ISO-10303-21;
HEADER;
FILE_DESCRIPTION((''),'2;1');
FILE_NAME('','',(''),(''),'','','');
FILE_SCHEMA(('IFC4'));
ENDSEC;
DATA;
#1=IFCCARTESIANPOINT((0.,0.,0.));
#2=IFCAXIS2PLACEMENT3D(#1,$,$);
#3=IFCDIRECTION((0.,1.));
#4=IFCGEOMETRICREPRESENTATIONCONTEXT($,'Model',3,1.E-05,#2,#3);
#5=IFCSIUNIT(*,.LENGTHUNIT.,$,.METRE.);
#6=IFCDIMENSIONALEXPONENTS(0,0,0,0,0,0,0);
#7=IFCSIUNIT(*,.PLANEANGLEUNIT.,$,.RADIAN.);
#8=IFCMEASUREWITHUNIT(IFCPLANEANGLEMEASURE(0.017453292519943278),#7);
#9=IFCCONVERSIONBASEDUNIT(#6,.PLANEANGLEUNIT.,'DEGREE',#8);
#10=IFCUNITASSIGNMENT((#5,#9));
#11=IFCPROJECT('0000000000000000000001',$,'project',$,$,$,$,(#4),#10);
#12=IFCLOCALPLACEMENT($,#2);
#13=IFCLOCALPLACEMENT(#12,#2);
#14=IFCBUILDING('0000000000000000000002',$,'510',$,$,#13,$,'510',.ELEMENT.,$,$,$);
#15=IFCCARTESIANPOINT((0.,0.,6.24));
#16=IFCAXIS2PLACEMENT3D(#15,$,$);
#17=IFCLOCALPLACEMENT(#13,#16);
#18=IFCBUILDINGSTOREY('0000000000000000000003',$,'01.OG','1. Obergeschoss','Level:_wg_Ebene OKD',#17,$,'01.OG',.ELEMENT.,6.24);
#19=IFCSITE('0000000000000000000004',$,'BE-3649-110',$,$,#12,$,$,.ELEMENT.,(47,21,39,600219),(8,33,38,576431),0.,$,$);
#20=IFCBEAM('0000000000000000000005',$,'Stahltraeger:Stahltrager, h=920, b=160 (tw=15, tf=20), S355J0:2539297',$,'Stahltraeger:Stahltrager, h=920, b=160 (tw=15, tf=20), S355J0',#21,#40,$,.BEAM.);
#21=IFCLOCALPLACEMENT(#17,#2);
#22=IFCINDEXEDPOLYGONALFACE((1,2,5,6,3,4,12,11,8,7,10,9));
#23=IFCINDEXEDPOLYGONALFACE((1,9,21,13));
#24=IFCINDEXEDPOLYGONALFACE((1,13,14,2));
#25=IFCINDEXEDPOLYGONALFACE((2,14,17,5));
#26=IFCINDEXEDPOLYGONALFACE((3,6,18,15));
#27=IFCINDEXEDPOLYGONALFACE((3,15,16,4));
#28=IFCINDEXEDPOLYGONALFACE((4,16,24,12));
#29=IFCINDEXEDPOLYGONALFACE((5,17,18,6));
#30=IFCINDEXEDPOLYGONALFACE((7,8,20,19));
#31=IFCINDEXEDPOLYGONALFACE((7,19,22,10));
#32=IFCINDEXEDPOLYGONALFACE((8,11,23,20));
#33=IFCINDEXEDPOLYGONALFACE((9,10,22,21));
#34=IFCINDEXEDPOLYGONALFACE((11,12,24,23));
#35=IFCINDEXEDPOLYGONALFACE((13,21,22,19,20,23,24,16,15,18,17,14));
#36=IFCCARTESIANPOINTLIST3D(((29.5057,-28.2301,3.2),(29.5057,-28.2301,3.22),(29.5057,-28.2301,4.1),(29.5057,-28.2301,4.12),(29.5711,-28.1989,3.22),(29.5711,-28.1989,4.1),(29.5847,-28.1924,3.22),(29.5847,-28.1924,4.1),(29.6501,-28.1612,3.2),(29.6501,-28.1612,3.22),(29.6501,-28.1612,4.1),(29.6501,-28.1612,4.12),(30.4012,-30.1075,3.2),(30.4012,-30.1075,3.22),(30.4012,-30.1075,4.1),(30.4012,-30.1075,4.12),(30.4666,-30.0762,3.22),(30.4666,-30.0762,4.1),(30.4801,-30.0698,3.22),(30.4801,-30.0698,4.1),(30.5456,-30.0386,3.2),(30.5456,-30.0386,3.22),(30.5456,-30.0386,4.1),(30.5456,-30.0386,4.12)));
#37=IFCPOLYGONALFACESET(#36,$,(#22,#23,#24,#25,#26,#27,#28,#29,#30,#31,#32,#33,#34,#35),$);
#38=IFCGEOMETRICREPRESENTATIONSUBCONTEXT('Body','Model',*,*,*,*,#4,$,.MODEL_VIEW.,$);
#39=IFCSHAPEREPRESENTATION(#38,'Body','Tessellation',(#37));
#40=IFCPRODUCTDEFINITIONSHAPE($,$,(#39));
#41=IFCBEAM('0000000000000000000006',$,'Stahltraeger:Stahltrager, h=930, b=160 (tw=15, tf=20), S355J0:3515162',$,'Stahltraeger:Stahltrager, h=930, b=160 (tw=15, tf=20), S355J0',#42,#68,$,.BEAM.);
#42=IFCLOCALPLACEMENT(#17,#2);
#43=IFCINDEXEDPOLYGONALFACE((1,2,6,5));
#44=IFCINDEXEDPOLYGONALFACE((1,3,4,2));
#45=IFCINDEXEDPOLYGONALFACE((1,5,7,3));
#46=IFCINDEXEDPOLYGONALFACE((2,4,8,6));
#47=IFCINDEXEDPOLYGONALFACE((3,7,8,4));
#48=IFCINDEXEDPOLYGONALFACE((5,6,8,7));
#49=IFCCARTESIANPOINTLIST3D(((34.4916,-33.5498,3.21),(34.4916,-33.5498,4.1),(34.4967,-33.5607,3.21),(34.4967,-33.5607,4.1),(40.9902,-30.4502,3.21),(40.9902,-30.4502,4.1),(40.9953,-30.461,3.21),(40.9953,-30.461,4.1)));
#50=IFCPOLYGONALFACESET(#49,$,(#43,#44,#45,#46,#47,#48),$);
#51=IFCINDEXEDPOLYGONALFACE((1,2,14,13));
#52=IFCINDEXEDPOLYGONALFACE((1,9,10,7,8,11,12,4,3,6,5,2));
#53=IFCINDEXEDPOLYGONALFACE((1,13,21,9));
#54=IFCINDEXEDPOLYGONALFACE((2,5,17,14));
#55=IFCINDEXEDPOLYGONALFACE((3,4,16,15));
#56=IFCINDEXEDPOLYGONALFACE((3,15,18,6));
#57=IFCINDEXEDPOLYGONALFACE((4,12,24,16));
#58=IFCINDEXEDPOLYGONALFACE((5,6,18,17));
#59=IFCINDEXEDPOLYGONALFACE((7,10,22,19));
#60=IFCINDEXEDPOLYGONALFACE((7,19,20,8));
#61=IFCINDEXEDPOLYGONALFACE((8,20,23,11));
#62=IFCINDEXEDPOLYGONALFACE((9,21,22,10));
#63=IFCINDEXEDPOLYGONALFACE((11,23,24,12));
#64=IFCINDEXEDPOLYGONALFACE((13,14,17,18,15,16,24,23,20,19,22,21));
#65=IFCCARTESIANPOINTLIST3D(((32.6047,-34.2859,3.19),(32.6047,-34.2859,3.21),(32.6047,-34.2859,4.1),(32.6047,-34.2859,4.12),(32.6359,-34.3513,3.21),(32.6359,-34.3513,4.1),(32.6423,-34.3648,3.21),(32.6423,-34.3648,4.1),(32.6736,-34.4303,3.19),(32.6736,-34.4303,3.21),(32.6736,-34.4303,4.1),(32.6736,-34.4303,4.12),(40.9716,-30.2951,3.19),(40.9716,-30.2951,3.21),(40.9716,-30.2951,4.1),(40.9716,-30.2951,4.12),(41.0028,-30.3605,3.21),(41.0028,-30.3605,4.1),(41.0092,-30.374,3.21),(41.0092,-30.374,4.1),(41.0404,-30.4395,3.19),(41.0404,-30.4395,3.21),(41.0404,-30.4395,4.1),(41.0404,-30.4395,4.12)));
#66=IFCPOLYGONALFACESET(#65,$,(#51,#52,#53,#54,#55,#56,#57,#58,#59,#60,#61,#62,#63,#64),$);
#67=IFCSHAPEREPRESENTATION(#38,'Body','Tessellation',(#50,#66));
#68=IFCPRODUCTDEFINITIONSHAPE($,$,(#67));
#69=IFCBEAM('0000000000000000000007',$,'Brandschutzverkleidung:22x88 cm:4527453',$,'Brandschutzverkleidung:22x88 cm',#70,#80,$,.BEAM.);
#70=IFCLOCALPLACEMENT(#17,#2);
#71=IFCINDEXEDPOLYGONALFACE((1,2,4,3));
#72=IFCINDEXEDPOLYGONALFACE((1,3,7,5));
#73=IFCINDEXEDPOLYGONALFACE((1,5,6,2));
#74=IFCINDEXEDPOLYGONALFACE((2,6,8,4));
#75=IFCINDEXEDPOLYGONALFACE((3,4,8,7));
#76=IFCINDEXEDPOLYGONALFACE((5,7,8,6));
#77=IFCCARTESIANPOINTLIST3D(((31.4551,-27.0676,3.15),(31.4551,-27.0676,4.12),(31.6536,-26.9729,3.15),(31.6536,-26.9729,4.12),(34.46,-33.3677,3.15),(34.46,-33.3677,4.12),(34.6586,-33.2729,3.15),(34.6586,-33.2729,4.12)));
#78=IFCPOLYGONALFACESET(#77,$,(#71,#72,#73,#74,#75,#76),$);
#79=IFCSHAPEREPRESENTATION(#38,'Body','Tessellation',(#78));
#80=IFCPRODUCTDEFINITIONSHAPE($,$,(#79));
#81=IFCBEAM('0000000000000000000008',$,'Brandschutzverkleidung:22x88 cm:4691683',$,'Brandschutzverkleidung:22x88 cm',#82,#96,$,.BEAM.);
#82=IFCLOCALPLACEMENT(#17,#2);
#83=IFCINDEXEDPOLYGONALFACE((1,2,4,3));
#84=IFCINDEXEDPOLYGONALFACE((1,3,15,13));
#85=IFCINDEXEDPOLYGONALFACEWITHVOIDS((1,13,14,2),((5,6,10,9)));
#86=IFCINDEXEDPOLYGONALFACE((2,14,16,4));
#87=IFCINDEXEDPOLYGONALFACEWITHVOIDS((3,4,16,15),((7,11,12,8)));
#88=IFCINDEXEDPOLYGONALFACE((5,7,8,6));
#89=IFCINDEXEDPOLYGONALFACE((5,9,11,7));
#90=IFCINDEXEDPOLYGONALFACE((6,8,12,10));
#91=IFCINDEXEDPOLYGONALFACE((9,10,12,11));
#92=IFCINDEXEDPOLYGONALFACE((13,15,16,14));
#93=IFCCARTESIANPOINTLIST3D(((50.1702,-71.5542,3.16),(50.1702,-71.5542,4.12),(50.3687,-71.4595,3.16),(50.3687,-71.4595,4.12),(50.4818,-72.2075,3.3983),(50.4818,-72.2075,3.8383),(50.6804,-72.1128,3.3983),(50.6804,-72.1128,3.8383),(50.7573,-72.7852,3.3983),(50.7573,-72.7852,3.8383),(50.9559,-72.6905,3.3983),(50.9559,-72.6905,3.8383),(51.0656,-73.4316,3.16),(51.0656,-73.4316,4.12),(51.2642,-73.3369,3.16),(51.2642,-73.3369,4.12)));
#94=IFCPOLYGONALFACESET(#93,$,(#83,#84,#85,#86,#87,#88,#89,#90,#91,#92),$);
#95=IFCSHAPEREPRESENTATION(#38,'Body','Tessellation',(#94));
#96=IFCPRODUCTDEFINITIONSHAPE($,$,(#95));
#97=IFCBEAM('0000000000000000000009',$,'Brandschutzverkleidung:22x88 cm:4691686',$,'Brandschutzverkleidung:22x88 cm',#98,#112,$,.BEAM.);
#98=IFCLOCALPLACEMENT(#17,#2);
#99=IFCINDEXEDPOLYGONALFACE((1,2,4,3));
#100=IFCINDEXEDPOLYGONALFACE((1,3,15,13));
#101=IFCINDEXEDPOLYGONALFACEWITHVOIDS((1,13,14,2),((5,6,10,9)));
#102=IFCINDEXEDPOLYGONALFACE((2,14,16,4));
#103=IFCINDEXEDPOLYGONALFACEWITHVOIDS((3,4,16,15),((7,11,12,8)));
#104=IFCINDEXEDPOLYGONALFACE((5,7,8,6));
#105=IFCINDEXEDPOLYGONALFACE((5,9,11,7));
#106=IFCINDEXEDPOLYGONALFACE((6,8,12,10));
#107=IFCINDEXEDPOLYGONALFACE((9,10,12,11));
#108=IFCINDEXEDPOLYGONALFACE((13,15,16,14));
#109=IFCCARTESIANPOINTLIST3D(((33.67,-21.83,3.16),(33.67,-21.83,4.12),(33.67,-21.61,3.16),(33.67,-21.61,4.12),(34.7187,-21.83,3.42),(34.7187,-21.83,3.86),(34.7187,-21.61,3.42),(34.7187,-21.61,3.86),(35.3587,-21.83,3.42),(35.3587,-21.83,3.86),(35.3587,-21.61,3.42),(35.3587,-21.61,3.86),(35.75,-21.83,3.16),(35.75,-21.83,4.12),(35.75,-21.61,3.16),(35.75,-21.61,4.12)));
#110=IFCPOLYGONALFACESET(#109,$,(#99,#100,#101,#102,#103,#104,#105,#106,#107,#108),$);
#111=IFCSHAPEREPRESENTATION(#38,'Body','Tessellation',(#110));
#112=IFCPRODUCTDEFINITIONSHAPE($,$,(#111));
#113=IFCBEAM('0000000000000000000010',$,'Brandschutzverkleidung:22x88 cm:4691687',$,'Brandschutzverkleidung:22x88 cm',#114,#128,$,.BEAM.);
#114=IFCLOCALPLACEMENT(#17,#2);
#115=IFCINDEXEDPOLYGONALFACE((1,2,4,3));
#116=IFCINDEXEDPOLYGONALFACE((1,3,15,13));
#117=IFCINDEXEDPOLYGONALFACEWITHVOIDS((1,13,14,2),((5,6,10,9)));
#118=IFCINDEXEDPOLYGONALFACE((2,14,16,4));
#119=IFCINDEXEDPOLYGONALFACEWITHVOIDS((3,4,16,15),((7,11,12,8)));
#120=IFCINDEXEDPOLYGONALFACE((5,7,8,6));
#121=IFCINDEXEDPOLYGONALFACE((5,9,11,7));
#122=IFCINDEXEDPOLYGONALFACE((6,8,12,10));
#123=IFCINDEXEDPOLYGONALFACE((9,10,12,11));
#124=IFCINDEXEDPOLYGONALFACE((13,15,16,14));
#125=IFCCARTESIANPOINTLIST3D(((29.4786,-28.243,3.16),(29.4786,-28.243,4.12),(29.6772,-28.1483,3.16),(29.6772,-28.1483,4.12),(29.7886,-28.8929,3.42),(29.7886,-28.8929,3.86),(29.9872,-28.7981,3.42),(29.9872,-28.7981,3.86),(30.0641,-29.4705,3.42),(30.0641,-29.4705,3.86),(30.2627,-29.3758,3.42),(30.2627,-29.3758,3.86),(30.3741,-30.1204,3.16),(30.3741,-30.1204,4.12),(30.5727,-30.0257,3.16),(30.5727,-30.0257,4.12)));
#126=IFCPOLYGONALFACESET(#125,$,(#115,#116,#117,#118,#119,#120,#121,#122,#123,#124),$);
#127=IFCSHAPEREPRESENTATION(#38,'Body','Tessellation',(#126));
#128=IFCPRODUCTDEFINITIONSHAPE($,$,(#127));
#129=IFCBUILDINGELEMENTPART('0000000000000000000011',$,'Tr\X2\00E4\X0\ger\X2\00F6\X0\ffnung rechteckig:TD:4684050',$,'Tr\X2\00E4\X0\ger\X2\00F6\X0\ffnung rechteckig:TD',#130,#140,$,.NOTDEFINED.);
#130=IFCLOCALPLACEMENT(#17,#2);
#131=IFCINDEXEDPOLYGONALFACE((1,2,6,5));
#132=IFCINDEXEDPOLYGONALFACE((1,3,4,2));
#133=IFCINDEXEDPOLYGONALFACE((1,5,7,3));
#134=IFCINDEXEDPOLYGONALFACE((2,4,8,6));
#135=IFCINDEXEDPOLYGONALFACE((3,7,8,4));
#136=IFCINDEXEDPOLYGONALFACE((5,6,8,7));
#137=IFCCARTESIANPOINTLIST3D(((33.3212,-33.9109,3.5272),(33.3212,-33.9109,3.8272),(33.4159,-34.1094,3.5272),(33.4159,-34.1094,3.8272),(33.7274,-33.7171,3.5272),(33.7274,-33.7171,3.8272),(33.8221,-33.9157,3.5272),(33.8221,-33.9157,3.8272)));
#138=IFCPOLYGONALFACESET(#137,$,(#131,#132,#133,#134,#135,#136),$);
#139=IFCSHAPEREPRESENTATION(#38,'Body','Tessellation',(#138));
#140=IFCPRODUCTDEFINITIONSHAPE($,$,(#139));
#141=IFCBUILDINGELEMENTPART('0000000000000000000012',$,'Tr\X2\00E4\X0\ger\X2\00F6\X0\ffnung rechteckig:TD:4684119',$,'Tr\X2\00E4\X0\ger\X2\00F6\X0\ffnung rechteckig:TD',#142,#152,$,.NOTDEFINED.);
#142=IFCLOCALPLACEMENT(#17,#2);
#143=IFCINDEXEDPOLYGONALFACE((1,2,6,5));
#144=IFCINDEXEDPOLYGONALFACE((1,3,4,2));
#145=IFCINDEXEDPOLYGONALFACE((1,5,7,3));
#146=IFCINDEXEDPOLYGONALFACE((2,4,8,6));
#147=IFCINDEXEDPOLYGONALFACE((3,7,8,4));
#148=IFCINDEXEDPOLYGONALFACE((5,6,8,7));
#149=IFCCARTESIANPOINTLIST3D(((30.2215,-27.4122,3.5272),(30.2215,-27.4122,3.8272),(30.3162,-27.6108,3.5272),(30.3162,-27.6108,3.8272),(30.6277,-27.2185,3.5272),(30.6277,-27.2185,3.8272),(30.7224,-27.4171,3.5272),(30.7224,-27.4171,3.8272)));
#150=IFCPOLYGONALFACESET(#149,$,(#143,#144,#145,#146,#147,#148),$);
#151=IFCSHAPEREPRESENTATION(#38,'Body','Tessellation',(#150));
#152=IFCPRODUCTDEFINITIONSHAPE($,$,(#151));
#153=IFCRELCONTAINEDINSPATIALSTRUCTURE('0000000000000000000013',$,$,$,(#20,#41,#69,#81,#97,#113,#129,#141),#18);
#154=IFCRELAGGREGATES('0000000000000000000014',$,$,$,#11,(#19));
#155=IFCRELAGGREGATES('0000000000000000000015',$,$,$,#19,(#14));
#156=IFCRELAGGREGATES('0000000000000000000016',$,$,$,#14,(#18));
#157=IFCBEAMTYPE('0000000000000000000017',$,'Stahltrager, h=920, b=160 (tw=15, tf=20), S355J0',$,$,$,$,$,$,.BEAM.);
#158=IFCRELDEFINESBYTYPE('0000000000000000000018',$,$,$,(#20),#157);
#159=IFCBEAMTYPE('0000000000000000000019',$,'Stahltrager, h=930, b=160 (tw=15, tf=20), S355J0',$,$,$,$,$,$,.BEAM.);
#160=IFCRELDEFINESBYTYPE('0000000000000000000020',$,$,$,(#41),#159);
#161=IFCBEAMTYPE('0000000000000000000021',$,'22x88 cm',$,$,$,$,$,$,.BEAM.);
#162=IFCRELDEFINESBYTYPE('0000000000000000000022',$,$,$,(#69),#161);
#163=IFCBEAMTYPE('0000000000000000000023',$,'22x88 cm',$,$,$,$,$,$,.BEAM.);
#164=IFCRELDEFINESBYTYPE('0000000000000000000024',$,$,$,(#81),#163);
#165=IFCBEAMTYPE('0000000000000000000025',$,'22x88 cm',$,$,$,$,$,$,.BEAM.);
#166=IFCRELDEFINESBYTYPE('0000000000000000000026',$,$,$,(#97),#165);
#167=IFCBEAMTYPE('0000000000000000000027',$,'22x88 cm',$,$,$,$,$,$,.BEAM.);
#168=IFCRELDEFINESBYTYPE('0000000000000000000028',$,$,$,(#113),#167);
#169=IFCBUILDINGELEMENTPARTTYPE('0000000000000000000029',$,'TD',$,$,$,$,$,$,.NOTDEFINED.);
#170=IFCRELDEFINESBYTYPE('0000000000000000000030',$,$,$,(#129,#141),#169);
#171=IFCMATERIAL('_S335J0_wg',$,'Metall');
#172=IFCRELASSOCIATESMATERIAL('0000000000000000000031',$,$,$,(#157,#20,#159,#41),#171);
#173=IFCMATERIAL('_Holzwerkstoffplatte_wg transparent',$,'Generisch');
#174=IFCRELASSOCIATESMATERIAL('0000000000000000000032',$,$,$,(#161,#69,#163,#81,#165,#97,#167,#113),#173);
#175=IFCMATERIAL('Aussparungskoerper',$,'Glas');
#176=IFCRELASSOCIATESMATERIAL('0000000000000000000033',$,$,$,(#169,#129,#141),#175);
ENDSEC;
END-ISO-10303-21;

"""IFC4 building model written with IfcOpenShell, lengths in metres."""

from ifc_helpers import new_model, entity, si_unit, converted_unit, direction, frame, origin, place, context, subcontext, project, spatial, indexed_curve, outline, extrude, source, transform, mapped, material, type_object, type_shapes, element, save


model = new_model("IFC4")

# Units and contexts
model_context = context("Model", 3, precision=1e-05, world=origin(), true_north=direction((0.0, 1.0)))
body_context = subcontext(model_context, "Body", "Model", "MODEL_VIEW")
ifc_project = project(units=[si_unit("LENGTHUNIT", "METRE"), converted_unit("PLANEANGLEUNIT", "DEGREE", entity("IfcPlaneAngleMeasure", 0.017453292519943278), si_unit("PLANEANGLEUNIT", "RADIAN"), dimensions=[0, 0, 0, 0, 0, 0, 0])], contexts=[model_context])

# Site, building, storey
site_placement = place(None, origin())
site = spatial("IfcSite", under=ifc_project, at=site_placement, Name="BE-3649-110", CompositionType="ELEMENT", RefLatitude=(47, 21, 39, 600219), RefLongitude=(8, 33, 38, 576431), RefElevation=0.0)
building_placement = place(site_placement, origin())
building = spatial("IfcBuilding", under=site, at=building_placement, Name="510", LongName="510", CompositionType="ELEMENT")
storey_placement = place(building_placement, frame((0.0, 0.0, 6.24)))
storey = spatial("IfcBuildingStorey", under=building, at=storey_placement, Name="01.OG", Description="1. Obergeschoss", ObjectType="Level:_wg_Ebene OKD", LongName="01.OG", CompositionType="ELEMENT", Elevation=6.24)

# Beams, openings
ifc_material_1 = material(Name="_S335J0_wg", Category="Metall")
beam_type_1 = type_object("IfcBeamType", Name="Stahltrager, h=920, b=160 (tw=15, tf=20), S355J0", PredefinedType="BEAM", material=ifc_material_1)
shared_shape_1 = source(origin(), body_context, "Body", "SweptSolid", [
    extrude(outline(indexed_curve([(-0.08, -0.44), (-0.08, -0.46), (0.08, -0.46), (0.08, -0.44), (0.0075, -0.44), (0.0075, 0.44), (0.08, 0.44), (0.08, 0.46), (-0.08, 0.46), (-0.08, 0.44), (-0.0075, 0.44), (-0.0075, -0.44), (-0.08, -0.44)], self_intersect=False)), frame((0.9677, 0.0344, 0.46), z_axis=(0.430511, -0.902585, 0.0), x_axis=(0.902585, 0.430511, 0.0)), (0.0, 0.0, -1.0), 2.08),
])
type_shapes(beam_type_1, [shared_shape_1])
beam_1_placement = place(storey_placement, frame((29.5057, -30.1075, 3.2)))
beam_1 = element("IfcBeam", 1, at=beam_1_placement, inside=storey, type_object=beam_type_1, material=ifc_material_1, Name="Stahltraeger:Stahltrager, h=920, b=160 (tw=15, tf=20), S355J0:2539297", ObjectType="Stahltraeger:Stahltrager, h=920, b=160 (tw=15, tf=20), S355J0", PredefinedType="BEAM", context=body_context, shape_type="MappedRepresentation", body=[
    mapped(shared_shape_1, transform((0.0, 0.0, 0.0), scale=1.0)),
])
opening_1_placement = place(storey_placement, frame((29.5057, -30.1075, 3.2)))
element("IfcOpeningElement", 2, at=opening_1_placement, cuts=beam_1, PredefinedType="OPENING", context=body_context, shape_type="SweptSolid", body=[
    extrude(outline(indexed_curve([(-0.32, -0.22), (0.32, -0.22), (0.32, 0.22), (-0.32, 0.22), (-0.32, -0.22)], self_intersect=False)), frame((0.5132, 0.9699, -5.8), z_axis=(0.902585, 0.430511, 0.0), x_axis=(-0.430511, 0.902585, 0.0)), (0.0, 0.0, 1.0), 0.015),
])
beam_type_2 = type_object("IfcBeamType", Name="Stahltrager, h=930, b=160 (tw=15, tf=20), S355J0", PredefinedType="BEAM", material=ifc_material_1)
shared_shape_2 = source(origin(), body_context, "Body", "SweptSolid", [
    extrude(outline(indexed_curve([(-0.445, -0.006), (0.445, -0.006), (0.445, 0.006), (-0.445, 0.006), (-0.445, -0.006)], self_intersect=False)), frame((1.8895, 0.875, 0.465), z_axis=(0.902585, 0.430511, 0.0), x_axis=(0.0, 0.0, -1.0)), (0.0, 0.0, 1.0), 7.2),
    extrude(outline(indexed_curve([(0.445, -0.08), (0.465, -0.08), (0.465, 0.08), (0.445, 0.08), (0.445, 0.0075), (-0.445, 0.0075), (-0.445, 0.08), (-0.465, 0.08), (-0.465, -0.08), (-0.445, -0.08), (-0.445, -0.0075), (0.445, -0.0075), (0.445, -0.08)], self_intersect=False)), frame((0.0344, 0.0722, 0.465), z_axis=(0.902585, 0.430511, 0.0), x_axis=(0.0, 0.0, -1.0)), (0.0, 0.0, 1.0), 9.2699),
])
type_shapes(beam_type_2, [shared_shape_2])
beam_2_placement = place(storey_placement, frame((32.6047, -34.4303, 3.19)))
beam_2 = element("IfcBeam", 3, at=beam_2_placement, inside=storey, type_object=beam_type_2, material=ifc_material_1, Name="Stahltraeger:Stahltrager, h=930, b=160 (tw=15, tf=20), S355J0:3515162", ObjectType="Stahltraeger:Stahltrager, h=930, b=160 (tw=15, tf=20), S355J0", PredefinedType="BEAM", context=body_context, shape_type="MappedRepresentation", body=[
    mapped(shared_shape_2, transform((0.0, 0.0, 0.0), scale=1.0)),
])
opening_2_placement = place(storey_placement, frame((32.6047, -34.4303, 3.19)))
element("IfcOpeningElement", 4, at=opening_2_placement, cuts=beam_2, PredefinedType="OPENING", context=body_context, shape_type="SweptSolid", body=[
    extrude(outline(indexed_curve([(-0.225, -0.15), (0.225, -0.15), (0.225, 0.15), (-0.225, 0.15), (-0.225, -0.15)], self_intersect=False)), frame((0.9702, 0.5102, -5.7528), z_axis=(-0.430511, 0.902585, 0.0), x_axis=(-0.902585, -0.430511, 0.0)), (0.0, 0.0, 1.0), 0.015),
])

# Beam
ifc_material_2 = material(Name="_Holzwerkstoffplatte_wg transparent", Category="Generisch")
beam_type_3 = type_object("IfcBeamType", Name="22x88 cm", PredefinedType="BEAM", material=ifc_material_2)
shared_shape_3 = source(origin(), body_context, "Body", "SweptSolid", [
    extrude(outline(indexed_curve([(-3.49, -0.11), (3.49, -0.11), (3.49, 0.11), (-3.49, 0.11), (-3.49, -0.11)], self_intersect=False)), frame((0.0, 0.0, -0.485)), (0.0, 0.0, 1.0), 0.97),
])
type_shapes(beam_type_3, [shared_shape_3])
beam_3_placement = place(storey_placement, frame((33.0568, -30.1703, 3.635), z_axis=(0.0, 0.0, 1.0), x_axis=(0.430511, -0.902585, 0.0)))
element("IfcBeam", 5, at=beam_3_placement, inside=storey, type_object=beam_type_3, material=ifc_material_2, Name="Brandschutzverkleidung:22x88 cm:4527453", ObjectType="Brandschutzverkleidung:22x88 cm", PredefinedType="BEAM", context=body_context, shape_type="MappedRepresentation", body=[
    mapped(shared_shape_3, transform((0.0, 0.0, 0.0), scale=1.0)),
])

# Beams
beam_type_4 = type_object("IfcBeamType", Name="22x88 cm", PredefinedType="BEAM", material=ifc_material_2)
shared_shape_4 = source(origin(), body_context, "Body", "SweptSolid", [
    extrude(outline(indexed_curve([(-1.04, -0.48), (1.04, -0.48), (1.04, 0.48), (-1.04, 0.48), (-1.04, -0.48)], self_intersect=False), holes=[indexed_curve([(0.3238, 0.2417), (0.3238, -0.1983), (-0.3162, -0.1983), (-0.3162, 0.2417), (0.3238, 0.2417)], self_intersect=False)]), frame((50.6179, -72.4929, 0.0), z_axis=(0.902585, 0.430511, 0.0), x_axis=(0.430511, -0.902585, 0.0)), (0.0, 0.0, 1.0), 0.22),
])
type_shapes(beam_type_4, [shared_shape_4])
beam_4_placement = place(storey_placement, frame((0.0, 0.0, 3.64)))
element("IfcBeam", 6, at=beam_4_placement, inside=storey, type_object=beam_type_4, material=ifc_material_2, Name="Brandschutzverkleidung:22x88 cm:4691683", ObjectType="Brandschutzverkleidung:22x88 cm", PredefinedType="BEAM", context=body_context, shape_type="MappedRepresentation", body=[
    mapped(shared_shape_4, transform((0.0, 0.0, 0.0), scale=1.0)),
])
beam_type_5 = type_object("IfcBeamType", Name="22x88 cm", PredefinedType="BEAM", material=ifc_material_2)
shared_shape_5 = source(origin(), body_context, "Body", "SweptSolid", [
    extrude(outline(indexed_curve([(-1.04, -0.48), (1.04, -0.48), (1.04, 0.48), (-1.04, 0.48), (-1.04, -0.48)], self_intersect=False), holes=[indexed_curve([(0.6487, 0.22), (0.6487, -0.22), (0.0087, -0.22), (0.0087, 0.22), (0.6487, 0.22)], self_intersect=False)]), frame((34.71, -21.83, 0.0), z_axis=(0.0, 1.0, 0.0), x_axis=(1.0, 0.0, 0.0)), (0.0, 0.0, 1.0), 0.22),
])
type_shapes(beam_type_5, [shared_shape_5])
beam_5_placement = place(storey_placement, frame((0.0, 0.0, 3.64)))
element("IfcBeam", 7, at=beam_5_placement, inside=storey, type_object=beam_type_5, material=ifc_material_2, Name="Brandschutzverkleidung:22x88 cm:4691686", ObjectType="Brandschutzverkleidung:22x88 cm", PredefinedType="BEAM", context=body_context, shape_type="MappedRepresentation", body=[
    mapped(shared_shape_5, transform((0.0, 0.0, 0.0), scale=1.0)),
])
beam_type_6 = type_object("IfcBeamType", Name="22x88 cm", PredefinedType="BEAM", material=ifc_material_2)
shared_shape_6 = source(origin(), body_context, "Body", "SweptSolid", [
    extrude(outline(indexed_curve([(-1.04, -0.48), (1.04, -0.48), (1.04, 0.48), (-1.04, 0.48), (-1.04, -0.48)], self_intersect=False), holes=[indexed_curve([(-0.32, -0.22), (-0.32, 0.22), (0.32, 0.22), (0.32, -0.22), (-0.32, -0.22)], self_intersect=False)]), frame((29.9264, -29.1817, 0.0), z_axis=(0.902585, 0.430511, 0.0), x_axis=(-0.430511, 0.902585, 0.0)), (0.0, 0.0, 1.0), 0.22),
])
type_shapes(beam_type_6, [shared_shape_6])
beam_6_placement = place(storey_placement, frame((0.0, 0.0, 3.64)))
element("IfcBeam", 8, at=beam_6_placement, inside=storey, type_object=beam_type_6, material=ifc_material_2, Name="Brandschutzverkleidung:22x88 cm:4691687", ObjectType="Brandschutzverkleidung:22x88 cm", PredefinedType="BEAM", context=body_context, shape_type="MappedRepresentation", body=[
    mapped(shared_shape_6, transform((0.0, 0.0, 0.0), scale=1.0)),
])

# Building element parts
ifc_material_3 = material(Name="Aussparungskoerper", Category="Glas")
building_element_part_type_1 = type_object("IfcBuildingElementPartType", Name="TD", PredefinedType="NOTDEFINED", material=ifc_material_3)
shared_shape_7 = source(origin(), body_context, "Body", "SweptSolid", [
    extrude(outline(indexed_curve([(-0.225, -0.15), (0.225, -0.15), (0.225, 0.15), (-0.225, 0.15), (-0.225, -0.15)], self_intersect=False)), frame((0.0, 0.0, -0.22), z_axis=(0.0, 0.0, 1.0), x_axis=(-1.0, 0.0, 0.0)), (0.0, 0.0, 1.0), 0.22),
])
type_shapes(building_element_part_type_1, [shared_shape_7])
for number, where, z_axis, x_axis, name in (
    (9, (33.619, -34.0126, 3.6772), (0.430511, -0.902585, 0.0), (-0.902585, -0.430511, 0.0), "Trägeröffnung rechteckig:TD:4684050"),
    (10, (30.5193, -27.5139, 3.6772), (0.430511, -0.902585, 0.0), (-0.902585, -0.430511, 0.0), "Trägeröffnung rechteckig:TD:4684119"),
):
    element("IfcBuildingElementPart", number, at=place(storey_placement, frame(where, z_axis=z_axis, x_axis=x_axis)), inside=storey, type_object=building_element_part_type_1, material=ifc_material_3, Name=name, ObjectType="Trägeröffnung rechteckig:TD", PredefinedType="NOTDEFINED", context=body_context, shape_type="MappedRepresentation", body=[
        mapped(shared_shape_7, transform((0.0, 0.0, 0.0), scale=1.0)),
    ])

save(model, "model.ifc")
